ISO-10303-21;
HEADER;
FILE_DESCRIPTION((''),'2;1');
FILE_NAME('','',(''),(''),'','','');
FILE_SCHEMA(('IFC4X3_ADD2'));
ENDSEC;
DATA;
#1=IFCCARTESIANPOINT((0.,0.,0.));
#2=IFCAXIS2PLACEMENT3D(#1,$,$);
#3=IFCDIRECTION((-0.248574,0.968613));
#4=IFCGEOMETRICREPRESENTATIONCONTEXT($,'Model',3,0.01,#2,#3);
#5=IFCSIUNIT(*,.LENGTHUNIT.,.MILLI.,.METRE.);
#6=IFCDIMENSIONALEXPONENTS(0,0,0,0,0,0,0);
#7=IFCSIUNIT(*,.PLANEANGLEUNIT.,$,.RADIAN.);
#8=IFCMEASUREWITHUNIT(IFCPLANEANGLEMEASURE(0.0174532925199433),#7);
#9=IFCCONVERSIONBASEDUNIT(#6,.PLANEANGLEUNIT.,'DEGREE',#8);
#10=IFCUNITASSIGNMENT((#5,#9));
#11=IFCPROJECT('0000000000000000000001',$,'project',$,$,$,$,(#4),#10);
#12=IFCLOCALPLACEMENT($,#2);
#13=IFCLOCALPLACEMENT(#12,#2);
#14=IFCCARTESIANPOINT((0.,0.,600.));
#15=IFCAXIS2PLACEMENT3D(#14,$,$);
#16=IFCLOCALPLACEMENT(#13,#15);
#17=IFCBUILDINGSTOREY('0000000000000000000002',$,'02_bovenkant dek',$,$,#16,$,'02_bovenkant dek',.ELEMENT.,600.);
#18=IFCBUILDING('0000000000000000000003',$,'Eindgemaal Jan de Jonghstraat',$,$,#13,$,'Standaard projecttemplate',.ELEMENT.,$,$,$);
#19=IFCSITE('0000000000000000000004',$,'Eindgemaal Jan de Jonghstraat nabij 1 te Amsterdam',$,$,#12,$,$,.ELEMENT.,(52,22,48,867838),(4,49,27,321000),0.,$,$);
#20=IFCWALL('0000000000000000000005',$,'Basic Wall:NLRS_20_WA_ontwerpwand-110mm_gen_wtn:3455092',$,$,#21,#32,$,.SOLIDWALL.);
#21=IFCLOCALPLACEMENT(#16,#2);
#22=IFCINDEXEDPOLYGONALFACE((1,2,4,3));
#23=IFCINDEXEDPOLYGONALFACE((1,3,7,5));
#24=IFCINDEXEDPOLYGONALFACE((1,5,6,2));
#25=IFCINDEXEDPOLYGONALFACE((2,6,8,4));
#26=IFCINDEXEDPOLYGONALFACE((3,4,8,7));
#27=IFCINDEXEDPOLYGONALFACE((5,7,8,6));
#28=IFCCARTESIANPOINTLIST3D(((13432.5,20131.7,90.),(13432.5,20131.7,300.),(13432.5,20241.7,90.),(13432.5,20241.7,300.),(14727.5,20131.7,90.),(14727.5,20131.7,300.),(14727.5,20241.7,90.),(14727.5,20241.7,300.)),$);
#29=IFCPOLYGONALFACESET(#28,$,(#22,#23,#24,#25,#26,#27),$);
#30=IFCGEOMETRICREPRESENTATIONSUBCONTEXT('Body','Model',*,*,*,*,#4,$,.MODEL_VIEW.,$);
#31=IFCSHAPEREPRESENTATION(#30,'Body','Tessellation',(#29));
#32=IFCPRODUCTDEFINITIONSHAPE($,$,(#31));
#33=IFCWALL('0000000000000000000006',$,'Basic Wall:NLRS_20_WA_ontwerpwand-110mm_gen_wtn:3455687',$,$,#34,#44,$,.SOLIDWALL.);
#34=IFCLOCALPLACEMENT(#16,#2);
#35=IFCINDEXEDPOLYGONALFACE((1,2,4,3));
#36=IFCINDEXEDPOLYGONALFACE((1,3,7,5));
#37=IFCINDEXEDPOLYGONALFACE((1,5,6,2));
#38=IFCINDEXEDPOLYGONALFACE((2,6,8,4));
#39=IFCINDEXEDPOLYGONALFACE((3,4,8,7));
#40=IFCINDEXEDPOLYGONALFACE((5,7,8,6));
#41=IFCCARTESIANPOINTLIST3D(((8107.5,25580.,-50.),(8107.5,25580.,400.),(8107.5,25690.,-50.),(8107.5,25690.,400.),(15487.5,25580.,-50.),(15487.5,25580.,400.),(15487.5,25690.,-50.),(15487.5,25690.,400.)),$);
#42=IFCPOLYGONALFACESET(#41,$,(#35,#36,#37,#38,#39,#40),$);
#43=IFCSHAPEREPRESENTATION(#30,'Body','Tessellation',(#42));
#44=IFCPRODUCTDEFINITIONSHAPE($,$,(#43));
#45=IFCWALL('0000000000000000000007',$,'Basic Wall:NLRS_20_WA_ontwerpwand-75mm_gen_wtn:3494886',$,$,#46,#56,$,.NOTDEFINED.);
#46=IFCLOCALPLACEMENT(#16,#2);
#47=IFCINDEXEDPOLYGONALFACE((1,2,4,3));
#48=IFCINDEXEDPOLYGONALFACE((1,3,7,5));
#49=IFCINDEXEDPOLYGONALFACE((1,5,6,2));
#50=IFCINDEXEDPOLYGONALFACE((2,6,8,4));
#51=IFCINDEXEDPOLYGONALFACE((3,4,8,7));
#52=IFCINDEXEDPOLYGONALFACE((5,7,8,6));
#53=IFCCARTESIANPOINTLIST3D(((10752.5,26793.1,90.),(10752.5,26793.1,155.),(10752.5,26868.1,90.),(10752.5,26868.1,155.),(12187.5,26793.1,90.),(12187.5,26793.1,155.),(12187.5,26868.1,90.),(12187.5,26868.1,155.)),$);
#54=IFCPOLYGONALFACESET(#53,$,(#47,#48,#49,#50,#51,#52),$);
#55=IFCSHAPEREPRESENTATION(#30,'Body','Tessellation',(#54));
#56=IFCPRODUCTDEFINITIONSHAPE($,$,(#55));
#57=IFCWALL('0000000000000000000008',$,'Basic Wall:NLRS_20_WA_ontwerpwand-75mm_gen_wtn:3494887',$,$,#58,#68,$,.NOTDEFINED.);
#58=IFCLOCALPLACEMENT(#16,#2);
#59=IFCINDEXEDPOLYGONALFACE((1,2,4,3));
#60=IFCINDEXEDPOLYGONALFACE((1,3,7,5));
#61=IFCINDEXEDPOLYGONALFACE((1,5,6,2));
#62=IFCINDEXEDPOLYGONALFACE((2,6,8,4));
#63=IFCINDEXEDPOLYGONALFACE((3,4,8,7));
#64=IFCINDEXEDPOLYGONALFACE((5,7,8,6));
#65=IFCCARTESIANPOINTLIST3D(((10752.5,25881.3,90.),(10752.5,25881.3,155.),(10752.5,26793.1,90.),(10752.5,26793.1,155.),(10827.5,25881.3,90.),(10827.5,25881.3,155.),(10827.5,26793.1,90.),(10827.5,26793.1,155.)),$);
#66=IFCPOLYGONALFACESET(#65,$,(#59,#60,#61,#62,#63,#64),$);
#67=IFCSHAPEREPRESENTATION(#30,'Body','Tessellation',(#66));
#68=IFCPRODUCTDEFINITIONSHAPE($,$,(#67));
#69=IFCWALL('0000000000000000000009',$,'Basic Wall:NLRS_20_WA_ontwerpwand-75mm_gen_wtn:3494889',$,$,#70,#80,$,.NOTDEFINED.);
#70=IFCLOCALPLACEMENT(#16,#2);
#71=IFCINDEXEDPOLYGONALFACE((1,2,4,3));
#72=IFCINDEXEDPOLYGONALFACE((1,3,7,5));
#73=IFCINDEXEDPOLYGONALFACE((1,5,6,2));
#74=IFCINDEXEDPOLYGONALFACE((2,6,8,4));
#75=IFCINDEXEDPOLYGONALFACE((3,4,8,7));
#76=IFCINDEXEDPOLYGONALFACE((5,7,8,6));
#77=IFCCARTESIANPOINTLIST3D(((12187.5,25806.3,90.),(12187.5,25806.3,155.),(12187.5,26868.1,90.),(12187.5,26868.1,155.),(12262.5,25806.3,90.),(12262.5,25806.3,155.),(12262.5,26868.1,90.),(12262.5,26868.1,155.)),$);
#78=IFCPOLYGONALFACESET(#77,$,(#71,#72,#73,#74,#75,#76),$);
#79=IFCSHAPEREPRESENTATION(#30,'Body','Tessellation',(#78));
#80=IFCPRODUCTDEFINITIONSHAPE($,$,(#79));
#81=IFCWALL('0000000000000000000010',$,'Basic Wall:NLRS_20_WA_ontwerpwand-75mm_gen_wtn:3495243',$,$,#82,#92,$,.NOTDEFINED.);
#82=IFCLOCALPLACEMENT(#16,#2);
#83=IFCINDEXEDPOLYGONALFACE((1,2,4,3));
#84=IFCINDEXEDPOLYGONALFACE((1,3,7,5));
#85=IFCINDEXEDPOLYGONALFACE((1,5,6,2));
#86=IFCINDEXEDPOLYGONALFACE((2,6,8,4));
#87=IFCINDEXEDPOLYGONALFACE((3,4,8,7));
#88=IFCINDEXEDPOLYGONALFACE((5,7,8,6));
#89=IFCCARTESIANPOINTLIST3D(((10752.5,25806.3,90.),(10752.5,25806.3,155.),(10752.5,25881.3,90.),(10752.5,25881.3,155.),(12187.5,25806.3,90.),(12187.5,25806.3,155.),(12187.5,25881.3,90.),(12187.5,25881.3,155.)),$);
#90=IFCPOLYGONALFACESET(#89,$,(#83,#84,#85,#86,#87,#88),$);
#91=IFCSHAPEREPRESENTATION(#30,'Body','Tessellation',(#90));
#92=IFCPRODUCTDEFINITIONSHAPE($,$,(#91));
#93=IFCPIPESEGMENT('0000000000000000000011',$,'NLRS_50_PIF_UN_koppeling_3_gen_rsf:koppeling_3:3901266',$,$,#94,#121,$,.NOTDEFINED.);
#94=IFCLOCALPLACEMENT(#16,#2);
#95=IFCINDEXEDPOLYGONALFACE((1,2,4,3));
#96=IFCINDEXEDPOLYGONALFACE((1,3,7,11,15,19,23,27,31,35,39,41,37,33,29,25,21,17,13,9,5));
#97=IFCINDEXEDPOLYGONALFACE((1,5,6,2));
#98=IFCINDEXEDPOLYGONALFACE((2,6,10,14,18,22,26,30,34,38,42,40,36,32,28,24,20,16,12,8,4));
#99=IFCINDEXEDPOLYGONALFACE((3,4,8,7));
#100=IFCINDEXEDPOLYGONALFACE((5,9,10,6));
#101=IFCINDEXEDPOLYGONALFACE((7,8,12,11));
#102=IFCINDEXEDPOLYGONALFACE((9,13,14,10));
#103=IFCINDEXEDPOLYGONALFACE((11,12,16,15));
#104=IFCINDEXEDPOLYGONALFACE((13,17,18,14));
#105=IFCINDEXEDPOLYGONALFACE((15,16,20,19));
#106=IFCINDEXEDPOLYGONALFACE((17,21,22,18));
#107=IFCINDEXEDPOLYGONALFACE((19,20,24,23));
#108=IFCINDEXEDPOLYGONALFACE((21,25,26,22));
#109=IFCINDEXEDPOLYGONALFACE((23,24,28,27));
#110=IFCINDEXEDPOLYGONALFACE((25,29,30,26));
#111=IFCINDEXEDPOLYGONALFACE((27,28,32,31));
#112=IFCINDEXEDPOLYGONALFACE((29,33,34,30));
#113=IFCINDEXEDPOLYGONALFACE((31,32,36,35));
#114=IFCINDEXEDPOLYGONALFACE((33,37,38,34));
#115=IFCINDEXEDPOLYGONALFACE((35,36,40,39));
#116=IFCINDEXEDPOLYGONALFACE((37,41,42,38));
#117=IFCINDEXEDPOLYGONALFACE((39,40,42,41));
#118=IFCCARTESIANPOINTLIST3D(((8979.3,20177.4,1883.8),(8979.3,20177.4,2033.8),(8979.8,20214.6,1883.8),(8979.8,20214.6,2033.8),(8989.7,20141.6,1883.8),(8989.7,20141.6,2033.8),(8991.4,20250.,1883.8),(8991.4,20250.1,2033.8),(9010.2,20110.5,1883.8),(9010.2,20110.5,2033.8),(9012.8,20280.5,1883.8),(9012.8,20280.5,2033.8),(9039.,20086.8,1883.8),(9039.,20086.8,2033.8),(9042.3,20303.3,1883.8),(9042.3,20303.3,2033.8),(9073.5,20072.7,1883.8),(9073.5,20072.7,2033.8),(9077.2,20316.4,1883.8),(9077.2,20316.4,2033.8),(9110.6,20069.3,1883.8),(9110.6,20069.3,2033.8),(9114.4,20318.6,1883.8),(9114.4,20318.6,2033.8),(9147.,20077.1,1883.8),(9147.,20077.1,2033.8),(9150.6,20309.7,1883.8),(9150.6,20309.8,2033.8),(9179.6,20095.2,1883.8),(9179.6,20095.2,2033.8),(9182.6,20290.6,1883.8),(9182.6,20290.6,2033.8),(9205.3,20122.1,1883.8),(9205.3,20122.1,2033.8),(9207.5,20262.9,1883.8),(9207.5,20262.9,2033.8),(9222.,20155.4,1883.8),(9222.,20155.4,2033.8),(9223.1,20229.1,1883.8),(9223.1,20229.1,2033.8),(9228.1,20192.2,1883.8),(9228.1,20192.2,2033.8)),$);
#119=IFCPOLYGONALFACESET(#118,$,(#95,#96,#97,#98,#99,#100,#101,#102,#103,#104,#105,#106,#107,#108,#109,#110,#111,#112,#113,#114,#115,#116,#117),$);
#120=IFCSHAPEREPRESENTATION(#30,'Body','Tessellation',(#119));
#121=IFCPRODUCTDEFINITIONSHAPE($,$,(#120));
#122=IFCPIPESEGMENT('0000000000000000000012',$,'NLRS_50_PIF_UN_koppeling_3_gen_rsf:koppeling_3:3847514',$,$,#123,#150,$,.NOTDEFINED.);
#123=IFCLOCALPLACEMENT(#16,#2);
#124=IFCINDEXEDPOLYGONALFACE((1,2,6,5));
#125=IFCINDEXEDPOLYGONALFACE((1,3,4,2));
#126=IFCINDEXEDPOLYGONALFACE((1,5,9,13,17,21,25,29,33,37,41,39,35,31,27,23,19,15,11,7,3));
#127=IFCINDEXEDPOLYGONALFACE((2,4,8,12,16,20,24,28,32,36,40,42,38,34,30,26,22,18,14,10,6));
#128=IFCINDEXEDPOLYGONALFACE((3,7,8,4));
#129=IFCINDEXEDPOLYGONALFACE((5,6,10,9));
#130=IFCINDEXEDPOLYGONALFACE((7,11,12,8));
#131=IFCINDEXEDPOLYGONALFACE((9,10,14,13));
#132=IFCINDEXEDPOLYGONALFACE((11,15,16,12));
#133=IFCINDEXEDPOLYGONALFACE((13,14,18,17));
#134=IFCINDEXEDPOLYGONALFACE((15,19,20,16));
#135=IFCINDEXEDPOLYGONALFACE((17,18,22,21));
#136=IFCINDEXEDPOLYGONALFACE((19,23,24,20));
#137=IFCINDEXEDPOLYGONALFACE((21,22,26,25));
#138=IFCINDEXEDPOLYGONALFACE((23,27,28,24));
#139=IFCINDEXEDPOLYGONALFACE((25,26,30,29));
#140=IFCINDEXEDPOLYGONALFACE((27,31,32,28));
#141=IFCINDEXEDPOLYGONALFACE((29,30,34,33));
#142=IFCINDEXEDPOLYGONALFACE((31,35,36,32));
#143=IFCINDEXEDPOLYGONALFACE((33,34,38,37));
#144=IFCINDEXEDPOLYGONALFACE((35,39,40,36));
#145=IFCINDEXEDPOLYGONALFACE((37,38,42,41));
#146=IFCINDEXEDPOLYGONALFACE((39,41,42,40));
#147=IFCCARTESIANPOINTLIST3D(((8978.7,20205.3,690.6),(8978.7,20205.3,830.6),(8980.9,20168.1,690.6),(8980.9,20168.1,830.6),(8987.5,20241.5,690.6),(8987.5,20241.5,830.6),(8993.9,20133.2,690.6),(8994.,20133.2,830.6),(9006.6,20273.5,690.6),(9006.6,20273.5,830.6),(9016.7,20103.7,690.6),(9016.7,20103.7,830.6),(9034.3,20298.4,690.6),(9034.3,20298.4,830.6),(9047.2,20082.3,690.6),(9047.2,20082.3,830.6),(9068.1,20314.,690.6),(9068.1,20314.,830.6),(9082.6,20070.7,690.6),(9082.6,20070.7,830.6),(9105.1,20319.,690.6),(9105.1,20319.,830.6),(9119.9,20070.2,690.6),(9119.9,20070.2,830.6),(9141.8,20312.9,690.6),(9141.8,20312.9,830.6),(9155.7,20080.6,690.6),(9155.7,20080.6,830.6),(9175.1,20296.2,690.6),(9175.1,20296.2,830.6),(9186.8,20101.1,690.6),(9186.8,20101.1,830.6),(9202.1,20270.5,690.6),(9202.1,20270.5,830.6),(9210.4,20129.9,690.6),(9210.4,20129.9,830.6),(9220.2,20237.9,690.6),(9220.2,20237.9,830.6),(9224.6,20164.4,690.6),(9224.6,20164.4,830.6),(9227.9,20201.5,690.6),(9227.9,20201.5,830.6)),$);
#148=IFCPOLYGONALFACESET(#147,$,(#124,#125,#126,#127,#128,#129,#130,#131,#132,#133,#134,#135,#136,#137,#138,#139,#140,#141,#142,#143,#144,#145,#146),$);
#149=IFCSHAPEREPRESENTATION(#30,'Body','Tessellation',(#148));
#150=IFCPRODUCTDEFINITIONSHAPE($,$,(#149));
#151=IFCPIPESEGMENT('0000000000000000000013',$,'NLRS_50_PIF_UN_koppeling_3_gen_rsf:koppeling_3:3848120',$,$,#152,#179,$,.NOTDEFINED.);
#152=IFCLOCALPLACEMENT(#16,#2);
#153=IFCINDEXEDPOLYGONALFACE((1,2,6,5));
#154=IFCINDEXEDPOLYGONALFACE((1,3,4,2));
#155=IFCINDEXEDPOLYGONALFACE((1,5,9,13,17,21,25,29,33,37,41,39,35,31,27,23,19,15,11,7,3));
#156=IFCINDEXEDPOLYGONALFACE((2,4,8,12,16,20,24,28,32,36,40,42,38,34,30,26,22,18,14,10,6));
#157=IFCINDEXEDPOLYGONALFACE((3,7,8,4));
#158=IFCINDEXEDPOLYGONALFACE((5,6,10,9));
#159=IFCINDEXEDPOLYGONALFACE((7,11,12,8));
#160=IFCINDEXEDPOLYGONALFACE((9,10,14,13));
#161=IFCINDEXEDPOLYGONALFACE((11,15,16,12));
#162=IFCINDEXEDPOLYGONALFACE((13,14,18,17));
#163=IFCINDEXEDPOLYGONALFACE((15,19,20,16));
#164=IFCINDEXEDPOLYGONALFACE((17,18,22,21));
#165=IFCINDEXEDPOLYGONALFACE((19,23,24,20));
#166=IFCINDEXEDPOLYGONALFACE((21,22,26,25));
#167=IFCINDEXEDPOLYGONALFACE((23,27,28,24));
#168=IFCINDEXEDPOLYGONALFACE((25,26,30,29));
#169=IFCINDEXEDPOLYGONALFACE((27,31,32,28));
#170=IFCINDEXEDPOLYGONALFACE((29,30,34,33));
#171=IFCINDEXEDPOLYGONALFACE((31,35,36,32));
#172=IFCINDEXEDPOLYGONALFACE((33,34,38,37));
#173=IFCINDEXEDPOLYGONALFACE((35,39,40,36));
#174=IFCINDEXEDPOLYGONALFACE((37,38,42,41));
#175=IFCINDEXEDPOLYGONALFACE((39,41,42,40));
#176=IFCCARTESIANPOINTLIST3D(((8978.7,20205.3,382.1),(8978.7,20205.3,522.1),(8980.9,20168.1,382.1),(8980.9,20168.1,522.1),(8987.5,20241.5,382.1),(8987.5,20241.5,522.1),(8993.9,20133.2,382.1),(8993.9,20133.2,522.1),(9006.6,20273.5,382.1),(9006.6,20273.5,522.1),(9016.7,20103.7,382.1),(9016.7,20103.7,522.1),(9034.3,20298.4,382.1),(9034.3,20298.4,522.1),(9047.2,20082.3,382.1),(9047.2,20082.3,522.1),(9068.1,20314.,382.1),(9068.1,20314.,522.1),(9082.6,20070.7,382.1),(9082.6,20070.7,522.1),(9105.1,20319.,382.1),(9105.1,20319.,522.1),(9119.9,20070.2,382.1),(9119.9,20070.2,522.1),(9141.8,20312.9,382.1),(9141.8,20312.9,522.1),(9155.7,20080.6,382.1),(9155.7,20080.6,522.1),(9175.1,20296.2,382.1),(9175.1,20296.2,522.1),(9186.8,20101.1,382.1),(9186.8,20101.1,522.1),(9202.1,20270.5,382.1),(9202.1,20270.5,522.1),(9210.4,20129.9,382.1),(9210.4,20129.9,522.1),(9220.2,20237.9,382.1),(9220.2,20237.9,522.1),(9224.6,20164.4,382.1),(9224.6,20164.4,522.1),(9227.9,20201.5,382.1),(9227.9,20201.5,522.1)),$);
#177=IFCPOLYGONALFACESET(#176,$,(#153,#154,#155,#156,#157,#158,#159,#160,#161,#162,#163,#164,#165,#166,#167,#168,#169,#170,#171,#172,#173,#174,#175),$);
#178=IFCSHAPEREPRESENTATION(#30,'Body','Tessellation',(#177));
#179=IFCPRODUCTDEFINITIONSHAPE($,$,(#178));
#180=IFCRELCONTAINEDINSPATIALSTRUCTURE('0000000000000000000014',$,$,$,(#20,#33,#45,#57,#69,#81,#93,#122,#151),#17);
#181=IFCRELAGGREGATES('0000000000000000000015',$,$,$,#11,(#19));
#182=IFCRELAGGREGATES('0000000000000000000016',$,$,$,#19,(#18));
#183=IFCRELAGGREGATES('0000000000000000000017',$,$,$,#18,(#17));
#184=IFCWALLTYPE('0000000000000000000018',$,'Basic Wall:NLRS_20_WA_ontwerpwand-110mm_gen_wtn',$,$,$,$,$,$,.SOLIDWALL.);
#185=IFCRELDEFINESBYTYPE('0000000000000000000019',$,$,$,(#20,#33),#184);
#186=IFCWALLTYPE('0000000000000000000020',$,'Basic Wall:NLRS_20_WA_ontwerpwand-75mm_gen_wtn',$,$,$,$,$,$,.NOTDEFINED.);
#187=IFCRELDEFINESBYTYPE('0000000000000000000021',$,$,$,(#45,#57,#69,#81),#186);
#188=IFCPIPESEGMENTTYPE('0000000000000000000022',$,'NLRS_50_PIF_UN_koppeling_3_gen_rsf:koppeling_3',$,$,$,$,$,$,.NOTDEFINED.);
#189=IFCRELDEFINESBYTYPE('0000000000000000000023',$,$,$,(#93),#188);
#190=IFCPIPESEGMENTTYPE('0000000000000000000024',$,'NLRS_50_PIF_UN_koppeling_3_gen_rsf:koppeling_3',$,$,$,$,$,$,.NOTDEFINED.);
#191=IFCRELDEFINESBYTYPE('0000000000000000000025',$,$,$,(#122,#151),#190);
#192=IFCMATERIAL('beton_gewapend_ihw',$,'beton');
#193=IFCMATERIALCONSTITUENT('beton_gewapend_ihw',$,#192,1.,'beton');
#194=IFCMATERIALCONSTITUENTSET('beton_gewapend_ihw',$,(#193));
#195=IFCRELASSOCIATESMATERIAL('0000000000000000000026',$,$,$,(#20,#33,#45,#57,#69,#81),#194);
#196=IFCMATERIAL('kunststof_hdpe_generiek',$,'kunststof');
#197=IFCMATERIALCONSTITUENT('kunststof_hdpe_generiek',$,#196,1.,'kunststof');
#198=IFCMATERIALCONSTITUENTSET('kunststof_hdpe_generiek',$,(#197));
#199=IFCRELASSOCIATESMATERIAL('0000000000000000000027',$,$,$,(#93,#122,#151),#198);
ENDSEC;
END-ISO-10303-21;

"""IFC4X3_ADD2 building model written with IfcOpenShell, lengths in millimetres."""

from ifc_helpers import new_model, entity, si_unit, converted_unit, direction, frame, frame_2d, origin, place, context, subcontext, project, spatial, rectangle, circle, extrude, source, transform, mapped, material, constituent, constituent_set, type_object, type_shapes, element, save


model = new_model("IFC4X3_ADD2")

# Units and contexts
model_context = context("Model", 3, precision=0.01, world=origin(), true_north=direction((-0.248574, 0.968613)))
body_context = subcontext(model_context, "Body", "Model", "MODEL_VIEW")
ifc_project = project(units=[si_unit("LENGTHUNIT", "METRE", prefix="MILLI"), converted_unit("PLANEANGLEUNIT", "DEGREE", entity("IfcPlaneAngleMeasure", 0.0174532925199433), si_unit("PLANEANGLEUNIT", "RADIAN"), dimensions=[0, 0, 0, 0, 0, 0, 0])], contexts=[model_context])

# Site, building, storey
site_placement = place(None, origin())
site = spatial("IfcSite", under=ifc_project, at=site_placement, Name="Eindgemaal Jan de Jonghstraat nabij 1 te Amsterdam", CompositionType="ELEMENT", RefLatitude=(52, 22, 48, 867838), RefLongitude=(4, 49, 27, 321000), RefElevation=0.0)
building_placement = place(site_placement, origin())
building = spatial("IfcBuilding", under=site, at=building_placement, Name="Eindgemaal Jan de Jonghstraat", LongName="Standaard projecttemplate", CompositionType="ELEMENT")
storey_placement = place(building_placement, frame((0.0, 0.0, 600.0)))
storey = spatial("IfcBuildingStorey", under=building, at=storey_placement, Name="02_bovenkant dek", LongName="02_bovenkant dek", CompositionType="ELEMENT", Elevation=600.0)

# Shared definitions
ifc_material_1 = material(Name="beton_gewapend_ihw", Category="beton")
ifc_constituent_1 = constituent(ifc_material_1, Name="beton_gewapend_ihw", Category="beton", fraction=1.0)
ifc_constituent_set_1 = constituent_set(constituents=[ifc_constituent_1], Name="beton_gewapend_ihw")

# Walls
wall_type_1 = type_object("IfcWallType", Name="Basic Wall:NLRS_20_WA_ontwerpwand-110mm_gen_wtn", PredefinedType="SOLIDWALL")
wall_1_placement = place(storey_placement, frame((13432.5, 20186.7, 90.0)))
element("IfcWall", 1, at=wall_1_placement, inside=storey, type_object=wall_type_1, material=ifc_constituent_set_1, Name="Basic Wall:NLRS_20_WA_ontwerpwand-110mm_gen_wtn:3455092", PredefinedType="SOLIDWALL", context=body_context, shape_type="SweptSolid", body=[
    extrude(rectangle(XDim=1295.0, YDim=110.0, at=frame_2d((647.5, 0.0), x_axis=(-1.0, 0.0))), origin(), (0.0, 0.0, 1.0), 210.0),
])
wall_2_placement = place(storey_placement, frame((15487.5, 25635.0, -50.0), z_axis=(0.0, 0.0, 1.0), x_axis=(-1.0, 0.0, 0.0)))
element("IfcWall", 2, at=wall_2_placement, inside=storey, type_object=wall_type_1, material=ifc_constituent_set_1, Name="Basic Wall:NLRS_20_WA_ontwerpwand-110mm_gen_wtn:3455687", PredefinedType="SOLIDWALL", context=body_context, shape_type="SweptSolid", body=[
    extrude(rectangle(XDim=7380.0, YDim=110.0, at=frame_2d((3690.0, 0.0), x_axis=(-1.0, 0.0))), origin(), (0.0, 0.0, 1.0), 450.0),
])
wall_type_2 = type_object("IfcWallType", Name="Basic Wall:NLRS_20_WA_ontwerpwand-75mm_gen_wtn", PredefinedType="NOTDEFINED")
wall_3_placement = place(storey_placement, frame((12187.5, 26830.6, 90.0), z_axis=(0.0, 0.0, 1.0), x_axis=(-1.0, 0.0, 0.0)))
element("IfcWall", 3, at=wall_3_placement, inside=storey, type_object=wall_type_2, material=ifc_constituent_set_1, Name="Basic Wall:NLRS_20_WA_ontwerpwand-75mm_gen_wtn:3494886", PredefinedType="NOTDEFINED", context=body_context, shape_type="SweptSolid", body=[
    extrude(rectangle(XDim=1435.0, YDim=75.0, at=frame_2d((717.5, 0.0), x_axis=(-1.0, 0.0))), origin(), (0.0, 0.0, 1.0), 65.0),
])
wall_4_placement = place(storey_placement, frame((10790.0, 26793.1, 90.0), z_axis=(0.0, 0.0, 1.0), x_axis=(0.0, -1.0, 0.0)))
element("IfcWall", 4, at=wall_4_placement, inside=storey, type_object=wall_type_2, material=ifc_constituent_set_1, Name="Basic Wall:NLRS_20_WA_ontwerpwand-75mm_gen_wtn:3494887", PredefinedType="NOTDEFINED", context=body_context, shape_type="SweptSolid", body=[
    extrude(rectangle(XDim=911.8, YDim=75.0, at=frame_2d((455.9, 0.0), x_axis=(-1.0, 0.0))), origin(), (0.0, 0.0, 1.0), 65.0),
])
wall_5_placement = place(storey_placement, frame((12225.0, 25806.3, 90.0), z_axis=(0.0, 0.0, 1.0), x_axis=(0.0, 1.0, 0.0)))
element("IfcWall", 5, at=wall_5_placement, inside=storey, type_object=wall_type_2, material=ifc_constituent_set_1, Name="Basic Wall:NLRS_20_WA_ontwerpwand-75mm_gen_wtn:3494889", PredefinedType="NOTDEFINED", context=body_context, shape_type="SweptSolid", body=[
    extrude(rectangle(XDim=1061.8, YDim=75.0, at=frame_2d((530.9, 0.0), x_axis=(-1.0, 0.0))), origin(), (0.0, 0.0, 1.0), 65.0),
])
wall_6_placement = place(storey_placement, frame((10752.5, 25843.8, 90.0)))
element("IfcWall", 6, at=wall_6_placement, inside=storey, type_object=wall_type_2, material=ifc_constituent_set_1, Name="Basic Wall:NLRS_20_WA_ontwerpwand-75mm_gen_wtn:3495243", PredefinedType="NOTDEFINED", context=body_context, shape_type="SweptSolid", body=[
    extrude(rectangle(XDim=1435.0, YDim=75.0, at=frame_2d((717.5, 0.0), x_axis=(-1.0, 0.0))), origin(), (0.0, 0.0, 1.0), 65.0),
])

# Pipe segments
ifc_material_2 = material(Name="kunststof_hdpe_generiek", Category="kunststof")
ifc_constituent_2 = constituent(ifc_material_2, Name="kunststof_hdpe_generiek", Category="kunststof", fraction=1.0)
ifc_constituent_set_2 = constituent_set(constituents=[ifc_constituent_2], Name="kunststof_hdpe_generiek")
pipe_segment_type_1 = type_object("IfcPipeSegmentType", Name="NLRS_50_PIF_UN_koppeling_3_gen_rsf:koppeling_3", PredefinedType="NOTDEFINED")
shared_shape_1 = source(origin(), body_context, "Body", "SweptSolid", [
    extrude(circle(Radius=125.0, at=frame_2d((0.0, 0.0), x_axis=(1.0, 0.0))), frame((0.0, 0.0, 0.0), z_axis=(1.0, 0.0, 0.0), x_axis=(0.0, 1.0, 0.0)), (0.0, 0.0, 1.0), 150.0),
])
type_shapes(pipe_segment_type_1, [shared_shape_1])
pipe_segment_1_placement = place(storey_placement, frame((9103.1, 20194.1, 2033.8), z_axis=(-0.668897, 0.743355, -0.000031), x_axis=(-0.000001, -0.000043, -1.0)))
element("IfcPipeSegment", 7, at=pipe_segment_1_placement, inside=storey, type_object=pipe_segment_type_1, material=ifc_constituent_set_2, Name="NLRS_50_PIF_UN_koppeling_3_gen_rsf:koppeling_3:3901266", PredefinedType="NOTDEFINED", context=body_context, shape_type="MappedRepresentation", body=[
    mapped(shared_shape_1, transform((0.0, 0.0, 0.0), scale=1.0)),
])
pipe_segment_type_2 = type_object("IfcPipeSegmentType", Name="NLRS_50_PIF_UN_koppeling_3_gen_rsf:koppeling_3", PredefinedType="NOTDEFINED")
shared_shape_2 = source(origin(), body_context, "Body", "SweptSolid", [
    extrude(circle(Radius=125.0, at=frame_2d((0.0, 0.0), x_axis=(1.0, 0.0))), frame((0.0, 0.0, 0.0), z_axis=(1.0, 0.0, 0.0), x_axis=(0.0, 1.0, 0.0)), (0.0, 0.0, 1.0), 140.0),
])
type_shapes(pipe_segment_type_2, [shared_shape_2])
for number, where, z_axis, x_axis, name in (
    (8, (9103.1, 20194.1, 830.6), (-0.743355, -0.668897, 0.000029), (-0.000001, -0.000043, -1.0), "NLRS_50_PIF_UN_koppeling_3_gen_rsf:koppeling_3:3847514"),
    (9, (9103.1, 20194.0, 522.1), (-0.743355, -0.668897, 0.000029), (-0.000001, -0.000043, -1.0), "NLRS_50_PIF_UN_koppeling_3_gen_rsf:koppeling_3:3848120"),
):
    element("IfcPipeSegment", number, at=place(storey_placement, frame(where, z_axis=z_axis, x_axis=x_axis)), inside=storey, type_object=pipe_segment_type_2, material=ifc_constituent_set_2, Name=name, PredefinedType="NOTDEFINED", context=body_context, shape_type="MappedRepresentation", body=[
        mapped(shared_shape_2, transform((0.0, 0.0, 0.0), scale=1.0)),
    ])

save(model, "model.ifc")
